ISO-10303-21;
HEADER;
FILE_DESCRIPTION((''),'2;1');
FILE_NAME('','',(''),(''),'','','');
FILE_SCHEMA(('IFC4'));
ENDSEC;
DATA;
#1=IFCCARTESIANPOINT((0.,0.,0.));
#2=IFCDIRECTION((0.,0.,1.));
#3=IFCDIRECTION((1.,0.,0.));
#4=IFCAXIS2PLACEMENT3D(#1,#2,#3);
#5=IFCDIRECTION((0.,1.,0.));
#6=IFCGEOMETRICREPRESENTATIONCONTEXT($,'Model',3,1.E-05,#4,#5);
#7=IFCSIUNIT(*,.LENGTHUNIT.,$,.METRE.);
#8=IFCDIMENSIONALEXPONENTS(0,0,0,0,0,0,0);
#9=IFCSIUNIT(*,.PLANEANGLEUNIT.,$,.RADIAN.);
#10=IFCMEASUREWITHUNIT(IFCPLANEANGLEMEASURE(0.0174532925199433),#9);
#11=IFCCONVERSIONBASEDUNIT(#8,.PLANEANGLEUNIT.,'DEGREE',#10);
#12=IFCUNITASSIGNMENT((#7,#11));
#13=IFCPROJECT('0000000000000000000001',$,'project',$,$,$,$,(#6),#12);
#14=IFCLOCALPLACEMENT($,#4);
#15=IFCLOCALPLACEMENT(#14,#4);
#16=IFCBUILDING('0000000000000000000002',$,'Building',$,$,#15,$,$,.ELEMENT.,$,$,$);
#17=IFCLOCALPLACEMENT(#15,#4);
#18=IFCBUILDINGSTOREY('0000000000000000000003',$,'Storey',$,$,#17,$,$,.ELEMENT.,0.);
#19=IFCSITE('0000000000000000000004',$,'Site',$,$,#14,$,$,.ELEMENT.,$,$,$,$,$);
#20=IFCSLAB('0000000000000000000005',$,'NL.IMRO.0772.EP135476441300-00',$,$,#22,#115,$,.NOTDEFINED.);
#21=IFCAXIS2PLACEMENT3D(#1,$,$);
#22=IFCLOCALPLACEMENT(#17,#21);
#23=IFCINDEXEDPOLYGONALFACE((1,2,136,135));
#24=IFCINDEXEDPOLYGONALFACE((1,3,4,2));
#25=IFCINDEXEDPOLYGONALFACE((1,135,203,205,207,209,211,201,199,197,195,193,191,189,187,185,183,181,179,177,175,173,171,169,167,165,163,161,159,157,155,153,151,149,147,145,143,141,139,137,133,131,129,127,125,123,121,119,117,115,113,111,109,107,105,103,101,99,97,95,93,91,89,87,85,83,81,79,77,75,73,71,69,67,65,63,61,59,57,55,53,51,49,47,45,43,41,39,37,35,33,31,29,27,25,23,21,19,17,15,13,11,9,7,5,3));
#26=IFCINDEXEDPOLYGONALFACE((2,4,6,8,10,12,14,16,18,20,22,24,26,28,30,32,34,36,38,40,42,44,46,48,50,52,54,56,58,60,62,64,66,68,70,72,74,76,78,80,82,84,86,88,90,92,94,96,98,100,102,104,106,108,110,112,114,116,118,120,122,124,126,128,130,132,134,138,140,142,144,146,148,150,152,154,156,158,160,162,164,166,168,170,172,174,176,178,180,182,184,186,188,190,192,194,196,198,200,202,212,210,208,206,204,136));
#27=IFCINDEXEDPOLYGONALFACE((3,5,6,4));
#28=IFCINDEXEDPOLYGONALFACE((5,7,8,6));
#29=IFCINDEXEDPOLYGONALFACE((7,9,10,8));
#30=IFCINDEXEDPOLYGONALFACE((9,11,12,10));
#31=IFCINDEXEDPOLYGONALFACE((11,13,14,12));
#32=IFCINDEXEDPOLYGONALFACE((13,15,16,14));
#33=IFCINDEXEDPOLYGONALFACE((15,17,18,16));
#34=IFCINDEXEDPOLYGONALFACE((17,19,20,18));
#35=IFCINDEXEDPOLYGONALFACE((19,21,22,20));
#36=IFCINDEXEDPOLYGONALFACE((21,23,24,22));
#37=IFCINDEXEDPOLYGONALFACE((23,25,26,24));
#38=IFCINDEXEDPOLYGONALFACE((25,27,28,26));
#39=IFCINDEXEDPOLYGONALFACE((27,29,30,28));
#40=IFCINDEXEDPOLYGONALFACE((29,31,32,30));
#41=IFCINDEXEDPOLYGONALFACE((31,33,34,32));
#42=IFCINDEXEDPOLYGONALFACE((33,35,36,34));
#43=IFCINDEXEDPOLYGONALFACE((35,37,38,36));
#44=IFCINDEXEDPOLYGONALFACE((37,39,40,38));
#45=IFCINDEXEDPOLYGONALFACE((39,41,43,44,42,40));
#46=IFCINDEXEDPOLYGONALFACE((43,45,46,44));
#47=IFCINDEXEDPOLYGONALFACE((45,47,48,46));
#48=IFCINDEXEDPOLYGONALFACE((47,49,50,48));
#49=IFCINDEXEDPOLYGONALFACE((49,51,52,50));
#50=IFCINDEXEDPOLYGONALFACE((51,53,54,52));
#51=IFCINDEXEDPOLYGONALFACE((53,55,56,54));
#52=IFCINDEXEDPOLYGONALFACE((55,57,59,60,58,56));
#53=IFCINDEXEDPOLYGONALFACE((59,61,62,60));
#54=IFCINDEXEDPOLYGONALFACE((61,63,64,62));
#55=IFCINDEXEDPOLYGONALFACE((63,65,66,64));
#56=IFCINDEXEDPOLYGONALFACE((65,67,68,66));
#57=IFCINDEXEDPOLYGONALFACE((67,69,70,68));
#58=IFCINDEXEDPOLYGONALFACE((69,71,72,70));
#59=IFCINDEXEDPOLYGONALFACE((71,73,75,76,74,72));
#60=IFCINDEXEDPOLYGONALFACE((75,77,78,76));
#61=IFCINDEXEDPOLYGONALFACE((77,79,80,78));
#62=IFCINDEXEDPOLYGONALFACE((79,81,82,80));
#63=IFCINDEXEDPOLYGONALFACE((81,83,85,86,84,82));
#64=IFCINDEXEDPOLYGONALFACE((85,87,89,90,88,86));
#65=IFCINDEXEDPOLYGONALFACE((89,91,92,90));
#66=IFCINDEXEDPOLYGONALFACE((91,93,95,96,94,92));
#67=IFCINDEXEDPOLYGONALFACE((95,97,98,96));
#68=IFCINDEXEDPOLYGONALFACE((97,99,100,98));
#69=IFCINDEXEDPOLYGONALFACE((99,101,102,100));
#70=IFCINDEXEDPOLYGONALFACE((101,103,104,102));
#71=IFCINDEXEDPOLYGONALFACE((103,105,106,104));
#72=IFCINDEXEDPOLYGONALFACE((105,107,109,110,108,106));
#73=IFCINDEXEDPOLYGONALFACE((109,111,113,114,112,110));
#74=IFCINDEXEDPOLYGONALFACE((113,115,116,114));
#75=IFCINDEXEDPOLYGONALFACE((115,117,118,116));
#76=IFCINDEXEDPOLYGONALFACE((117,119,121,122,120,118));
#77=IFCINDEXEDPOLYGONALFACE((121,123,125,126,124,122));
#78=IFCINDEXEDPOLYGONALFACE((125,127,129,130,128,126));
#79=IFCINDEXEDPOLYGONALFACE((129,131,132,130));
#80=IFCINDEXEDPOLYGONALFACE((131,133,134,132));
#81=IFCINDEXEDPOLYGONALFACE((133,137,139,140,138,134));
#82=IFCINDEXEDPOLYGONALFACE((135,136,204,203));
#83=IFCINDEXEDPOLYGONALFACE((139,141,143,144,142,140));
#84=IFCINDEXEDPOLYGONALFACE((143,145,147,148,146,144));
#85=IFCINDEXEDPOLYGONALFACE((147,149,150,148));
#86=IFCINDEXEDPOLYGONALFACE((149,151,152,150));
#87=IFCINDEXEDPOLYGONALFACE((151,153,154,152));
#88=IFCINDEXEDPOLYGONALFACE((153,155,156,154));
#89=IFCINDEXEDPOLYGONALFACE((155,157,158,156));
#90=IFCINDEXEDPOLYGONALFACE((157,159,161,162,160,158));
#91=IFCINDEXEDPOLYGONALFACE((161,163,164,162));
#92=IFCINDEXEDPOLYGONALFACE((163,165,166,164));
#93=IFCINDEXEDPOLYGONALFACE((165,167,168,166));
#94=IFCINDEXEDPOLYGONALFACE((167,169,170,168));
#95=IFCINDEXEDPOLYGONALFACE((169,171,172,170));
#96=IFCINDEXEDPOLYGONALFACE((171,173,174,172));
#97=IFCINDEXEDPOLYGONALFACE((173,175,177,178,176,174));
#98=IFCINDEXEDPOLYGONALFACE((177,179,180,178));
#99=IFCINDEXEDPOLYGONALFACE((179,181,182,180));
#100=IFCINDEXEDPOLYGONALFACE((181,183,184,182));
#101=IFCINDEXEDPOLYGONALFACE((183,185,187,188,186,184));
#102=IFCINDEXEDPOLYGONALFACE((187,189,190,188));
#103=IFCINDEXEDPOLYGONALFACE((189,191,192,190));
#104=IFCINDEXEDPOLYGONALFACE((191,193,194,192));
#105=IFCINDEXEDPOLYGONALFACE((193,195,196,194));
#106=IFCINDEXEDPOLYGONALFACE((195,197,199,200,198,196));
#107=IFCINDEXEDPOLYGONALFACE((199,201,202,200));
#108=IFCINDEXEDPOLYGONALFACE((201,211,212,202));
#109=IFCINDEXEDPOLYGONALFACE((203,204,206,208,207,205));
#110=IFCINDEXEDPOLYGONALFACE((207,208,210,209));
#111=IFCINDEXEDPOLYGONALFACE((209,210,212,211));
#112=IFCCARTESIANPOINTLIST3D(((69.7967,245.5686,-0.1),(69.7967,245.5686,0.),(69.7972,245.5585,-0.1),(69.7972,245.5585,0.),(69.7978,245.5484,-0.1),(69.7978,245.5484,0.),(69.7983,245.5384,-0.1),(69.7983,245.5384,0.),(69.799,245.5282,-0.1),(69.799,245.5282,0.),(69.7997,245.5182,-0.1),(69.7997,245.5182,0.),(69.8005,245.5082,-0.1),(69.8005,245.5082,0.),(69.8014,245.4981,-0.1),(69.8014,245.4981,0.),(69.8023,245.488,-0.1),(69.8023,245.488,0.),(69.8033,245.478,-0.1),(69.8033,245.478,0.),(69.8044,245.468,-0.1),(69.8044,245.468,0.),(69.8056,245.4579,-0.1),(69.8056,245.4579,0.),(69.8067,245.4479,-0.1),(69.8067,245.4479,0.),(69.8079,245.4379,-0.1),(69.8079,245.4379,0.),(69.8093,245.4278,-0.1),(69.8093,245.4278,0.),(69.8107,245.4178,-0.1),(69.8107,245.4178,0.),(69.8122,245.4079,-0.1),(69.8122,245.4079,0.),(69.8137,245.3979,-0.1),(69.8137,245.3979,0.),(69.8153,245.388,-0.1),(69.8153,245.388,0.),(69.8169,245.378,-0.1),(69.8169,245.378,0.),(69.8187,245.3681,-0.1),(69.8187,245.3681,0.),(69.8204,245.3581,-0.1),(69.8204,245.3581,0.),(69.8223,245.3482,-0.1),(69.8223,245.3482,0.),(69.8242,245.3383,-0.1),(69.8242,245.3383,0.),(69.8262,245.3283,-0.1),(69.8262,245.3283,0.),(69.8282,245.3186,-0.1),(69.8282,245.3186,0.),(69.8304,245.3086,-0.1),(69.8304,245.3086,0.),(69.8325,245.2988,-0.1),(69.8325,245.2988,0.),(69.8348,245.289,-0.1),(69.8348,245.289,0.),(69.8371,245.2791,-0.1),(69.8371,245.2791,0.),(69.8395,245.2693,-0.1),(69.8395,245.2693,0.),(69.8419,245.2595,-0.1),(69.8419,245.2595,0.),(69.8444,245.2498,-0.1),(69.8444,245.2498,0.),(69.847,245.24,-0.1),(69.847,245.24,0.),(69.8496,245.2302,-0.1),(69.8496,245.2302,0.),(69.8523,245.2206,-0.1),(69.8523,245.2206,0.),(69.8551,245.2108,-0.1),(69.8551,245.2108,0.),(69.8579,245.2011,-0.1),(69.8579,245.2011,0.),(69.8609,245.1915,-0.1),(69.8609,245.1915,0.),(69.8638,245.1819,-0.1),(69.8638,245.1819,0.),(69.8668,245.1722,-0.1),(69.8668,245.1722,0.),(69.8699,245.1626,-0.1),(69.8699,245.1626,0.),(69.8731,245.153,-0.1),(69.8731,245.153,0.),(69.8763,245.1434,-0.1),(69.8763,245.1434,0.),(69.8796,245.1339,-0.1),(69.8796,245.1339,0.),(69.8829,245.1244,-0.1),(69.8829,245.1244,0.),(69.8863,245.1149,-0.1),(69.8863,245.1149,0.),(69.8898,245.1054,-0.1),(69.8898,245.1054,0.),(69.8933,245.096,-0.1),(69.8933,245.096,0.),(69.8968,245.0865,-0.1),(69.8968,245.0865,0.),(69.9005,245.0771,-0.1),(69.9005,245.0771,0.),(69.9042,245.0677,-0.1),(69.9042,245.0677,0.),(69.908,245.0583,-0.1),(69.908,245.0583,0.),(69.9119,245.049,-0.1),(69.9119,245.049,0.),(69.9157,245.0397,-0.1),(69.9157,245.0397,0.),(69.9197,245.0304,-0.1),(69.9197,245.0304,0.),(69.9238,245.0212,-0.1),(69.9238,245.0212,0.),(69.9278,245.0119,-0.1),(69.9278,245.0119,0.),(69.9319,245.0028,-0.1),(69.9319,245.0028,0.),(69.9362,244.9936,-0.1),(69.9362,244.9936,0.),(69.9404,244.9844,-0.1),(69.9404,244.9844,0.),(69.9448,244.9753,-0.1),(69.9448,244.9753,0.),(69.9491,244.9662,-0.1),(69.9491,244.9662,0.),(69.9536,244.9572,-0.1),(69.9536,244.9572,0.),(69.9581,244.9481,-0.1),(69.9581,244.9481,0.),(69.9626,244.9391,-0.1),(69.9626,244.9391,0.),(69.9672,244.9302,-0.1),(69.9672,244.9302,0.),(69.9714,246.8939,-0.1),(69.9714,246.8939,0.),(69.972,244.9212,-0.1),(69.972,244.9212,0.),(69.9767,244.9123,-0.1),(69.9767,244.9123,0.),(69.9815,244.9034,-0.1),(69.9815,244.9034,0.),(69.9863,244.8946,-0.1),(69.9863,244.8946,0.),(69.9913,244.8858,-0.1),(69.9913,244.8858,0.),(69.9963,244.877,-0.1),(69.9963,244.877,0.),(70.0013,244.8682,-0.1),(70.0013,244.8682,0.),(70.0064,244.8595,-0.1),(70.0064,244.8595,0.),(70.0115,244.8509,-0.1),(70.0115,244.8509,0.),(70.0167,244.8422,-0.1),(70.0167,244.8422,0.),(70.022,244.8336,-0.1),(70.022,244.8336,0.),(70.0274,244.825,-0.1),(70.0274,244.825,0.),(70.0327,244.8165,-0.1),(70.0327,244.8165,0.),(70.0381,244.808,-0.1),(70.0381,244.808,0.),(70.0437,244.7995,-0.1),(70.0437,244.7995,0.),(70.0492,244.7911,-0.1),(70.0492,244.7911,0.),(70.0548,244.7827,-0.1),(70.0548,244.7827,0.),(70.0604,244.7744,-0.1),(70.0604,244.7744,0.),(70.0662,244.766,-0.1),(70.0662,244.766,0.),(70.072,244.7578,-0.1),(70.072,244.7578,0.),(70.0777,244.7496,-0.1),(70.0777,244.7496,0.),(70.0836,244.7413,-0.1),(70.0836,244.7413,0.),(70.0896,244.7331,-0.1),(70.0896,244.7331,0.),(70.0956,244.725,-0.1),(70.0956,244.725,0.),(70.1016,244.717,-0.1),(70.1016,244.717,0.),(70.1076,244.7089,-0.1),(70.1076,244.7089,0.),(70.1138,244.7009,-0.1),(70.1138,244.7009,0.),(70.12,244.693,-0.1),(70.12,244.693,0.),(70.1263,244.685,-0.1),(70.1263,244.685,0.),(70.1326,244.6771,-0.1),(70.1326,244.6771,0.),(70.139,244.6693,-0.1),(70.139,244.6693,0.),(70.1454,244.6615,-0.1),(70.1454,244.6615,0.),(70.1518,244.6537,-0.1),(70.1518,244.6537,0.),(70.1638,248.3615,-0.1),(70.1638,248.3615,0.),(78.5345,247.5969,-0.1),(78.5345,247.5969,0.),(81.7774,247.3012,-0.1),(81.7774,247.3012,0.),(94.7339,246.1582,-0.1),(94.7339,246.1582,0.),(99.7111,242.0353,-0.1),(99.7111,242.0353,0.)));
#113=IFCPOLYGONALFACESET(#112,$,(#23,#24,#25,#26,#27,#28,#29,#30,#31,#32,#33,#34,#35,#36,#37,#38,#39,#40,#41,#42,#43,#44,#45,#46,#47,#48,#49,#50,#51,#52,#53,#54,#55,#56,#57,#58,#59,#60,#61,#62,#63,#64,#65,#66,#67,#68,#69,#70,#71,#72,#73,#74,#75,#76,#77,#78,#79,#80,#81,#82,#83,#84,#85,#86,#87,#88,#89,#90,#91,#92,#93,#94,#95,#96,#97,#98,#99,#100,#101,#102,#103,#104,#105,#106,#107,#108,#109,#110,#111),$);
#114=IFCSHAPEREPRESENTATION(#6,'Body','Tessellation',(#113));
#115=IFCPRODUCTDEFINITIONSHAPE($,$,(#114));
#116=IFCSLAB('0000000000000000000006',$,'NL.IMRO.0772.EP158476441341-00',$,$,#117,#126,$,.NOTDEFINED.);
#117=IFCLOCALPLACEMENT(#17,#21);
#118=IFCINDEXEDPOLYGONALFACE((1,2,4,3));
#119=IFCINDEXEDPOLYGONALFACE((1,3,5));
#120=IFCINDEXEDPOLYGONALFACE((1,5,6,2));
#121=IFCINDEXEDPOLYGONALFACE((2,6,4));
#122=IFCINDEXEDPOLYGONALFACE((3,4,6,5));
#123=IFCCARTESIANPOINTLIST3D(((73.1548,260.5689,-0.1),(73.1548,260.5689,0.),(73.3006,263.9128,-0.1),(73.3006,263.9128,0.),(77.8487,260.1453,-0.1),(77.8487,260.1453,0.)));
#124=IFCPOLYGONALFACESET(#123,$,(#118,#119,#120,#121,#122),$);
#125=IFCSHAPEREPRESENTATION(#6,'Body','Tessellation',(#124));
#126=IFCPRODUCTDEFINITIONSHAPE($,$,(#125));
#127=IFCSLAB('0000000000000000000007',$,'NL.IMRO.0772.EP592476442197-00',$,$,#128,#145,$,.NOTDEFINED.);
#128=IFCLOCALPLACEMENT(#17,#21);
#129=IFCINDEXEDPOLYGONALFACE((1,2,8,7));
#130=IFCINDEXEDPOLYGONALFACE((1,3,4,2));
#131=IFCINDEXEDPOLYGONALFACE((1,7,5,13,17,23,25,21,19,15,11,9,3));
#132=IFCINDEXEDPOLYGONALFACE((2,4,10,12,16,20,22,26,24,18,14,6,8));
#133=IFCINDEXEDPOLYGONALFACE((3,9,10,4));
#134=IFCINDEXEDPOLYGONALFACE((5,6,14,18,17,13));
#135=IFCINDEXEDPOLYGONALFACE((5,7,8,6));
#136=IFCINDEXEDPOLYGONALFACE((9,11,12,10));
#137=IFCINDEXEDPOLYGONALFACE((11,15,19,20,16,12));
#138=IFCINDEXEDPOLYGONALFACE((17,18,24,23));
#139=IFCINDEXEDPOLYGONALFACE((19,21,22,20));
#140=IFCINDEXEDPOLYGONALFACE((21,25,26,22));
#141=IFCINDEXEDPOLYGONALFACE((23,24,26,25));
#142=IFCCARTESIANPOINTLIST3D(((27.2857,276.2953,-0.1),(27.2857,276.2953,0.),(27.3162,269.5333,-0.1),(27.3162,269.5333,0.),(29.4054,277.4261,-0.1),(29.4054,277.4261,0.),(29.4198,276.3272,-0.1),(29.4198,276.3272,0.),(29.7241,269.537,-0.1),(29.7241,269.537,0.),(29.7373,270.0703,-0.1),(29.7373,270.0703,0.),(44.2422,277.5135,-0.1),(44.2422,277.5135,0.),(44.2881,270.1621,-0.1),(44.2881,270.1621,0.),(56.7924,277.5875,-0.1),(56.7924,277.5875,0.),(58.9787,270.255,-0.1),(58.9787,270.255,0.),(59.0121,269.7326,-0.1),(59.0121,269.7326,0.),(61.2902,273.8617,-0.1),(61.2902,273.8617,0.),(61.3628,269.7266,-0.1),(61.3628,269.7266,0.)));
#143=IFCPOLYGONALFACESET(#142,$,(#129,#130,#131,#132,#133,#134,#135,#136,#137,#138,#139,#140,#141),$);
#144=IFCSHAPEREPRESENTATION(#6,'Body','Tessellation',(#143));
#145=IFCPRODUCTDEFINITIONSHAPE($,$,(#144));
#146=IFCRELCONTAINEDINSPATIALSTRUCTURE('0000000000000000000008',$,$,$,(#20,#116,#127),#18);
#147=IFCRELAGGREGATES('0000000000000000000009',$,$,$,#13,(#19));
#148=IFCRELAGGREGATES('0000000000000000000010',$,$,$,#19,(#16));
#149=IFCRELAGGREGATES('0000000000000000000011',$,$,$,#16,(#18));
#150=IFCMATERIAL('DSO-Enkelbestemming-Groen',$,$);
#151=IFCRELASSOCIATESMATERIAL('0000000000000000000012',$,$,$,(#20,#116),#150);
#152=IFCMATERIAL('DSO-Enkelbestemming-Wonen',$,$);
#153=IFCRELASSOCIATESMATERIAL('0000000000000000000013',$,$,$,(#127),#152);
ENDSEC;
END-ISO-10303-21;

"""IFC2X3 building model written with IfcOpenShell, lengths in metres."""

from ifc_helpers import new_model, entity, si_unit, converted_unit, direction, frame, origin_with_axes, place, context, project, spatial, polyline, outline, extrude, material, element, save


model = new_model("IFC2X3")

# Units and contexts
model_context = context("Model", 3, precision=1e-05, world=origin_with_axes(), true_north=direction((0.0, 1.0, 0.0)))
ifc_project = project(units=[si_unit("LENGTHUNIT", "METRE"), converted_unit("PLANEANGLEUNIT", "DEGREE", entity("IfcPlaneAngleMeasure", 0.0174532925199433), si_unit("PLANEANGLEUNIT", "RADIAN"), dimensions=[0, 0, 0, 0, 0, 0, 0])], contexts=[model_context])

# Site, building, storey
site_placement = place(None, origin_with_axes())
site = spatial("IfcSite", under=ifc_project, at=site_placement, Name="Site", CompositionType="ELEMENT")
building_placement = place(site_placement, origin_with_axes())
building = spatial("IfcBuilding", under=site, at=building_placement, Name="Building", CompositionType="ELEMENT")
storey_placement = place(building_placement, origin_with_axes())
storey = spatial("IfcBuildingStorey", under=building, at=storey_placement, Name="Storey", CompositionType="ELEMENT", Elevation=0.0)

# Slabs
ifc_material_1 = material(Name="DSO-Enkelbestemming-Wonen")
ifc_material_2 = material(Name="DSO-Enkelbestemming-Groen")
slab_1_placement = place(storey_placement, frame((0.0, 0.0, -0.1), z_axis=(0.0, 0.0, 1.0), x_axis=(1.0, 0.0, 0.0)))
element("IfcSlab", 1, at=slab_1_placement, inside=storey, material=ifc_material_2, Name="NL.IMRO.0772.EP135476441300-00", PredefinedType="NOTDEFINED", context=model_context, shape_type="SweptSolid", body=[
    extrude(outline(polyline([(70.1518, 244.6537), (70.1454, 244.6615), (70.139, 244.6693), (70.1326, 244.6771), (70.1263, 244.685), (70.12, 244.693), (70.1138, 244.7009), (70.1076, 244.7089), (70.1016, 244.717), (70.0956, 244.725), (70.0896, 244.7331), (70.0836, 244.7413), (70.0777, 244.7496), (70.072, 244.7578), (70.0662, 244.766), (70.0604, 244.7744), (70.0548, 244.7827), (70.0492, 244.7911), (70.0437, 244.7995), (70.0381, 244.808), (70.0327, 244.8165), (70.0274, 244.825), (70.022, 244.8336), (70.0167, 244.8422), (70.0115, 244.8509), (70.0064, 244.8595), (70.0013, 244.8682), (69.9963, 244.877), (69.9913, 244.8858), (69.9863, 244.8946), (69.9815, 244.9034), (69.9767, 244.9123), (69.972, 244.9212), (69.9672, 244.9302), (69.9626, 244.9391), (69.9581, 244.9481), (69.9536, 244.9572), (69.9491, 244.9662), (69.9448, 244.9753), (69.9404, 244.9844), (69.9362, 244.9936), (69.9319, 245.0028), (69.9278, 245.0119), (69.9238, 245.0212), (69.9197, 245.0304), (69.9157, 245.0397), (69.9119, 245.049), (69.908, 245.0583), (69.9042, 245.0677), (69.9005, 245.0771), (69.8968, 245.0865), (69.8933, 245.096), (69.8898, 245.1054), (69.8863, 245.1149), (69.8829, 245.1244), (69.8796, 245.1339), (69.8763, 245.1434), (69.8731, 245.153), (69.8699, 245.1626), (69.8668, 245.1722), (69.8638, 245.1819), (69.8609, 245.1915), (69.8579, 245.2011), (69.8551, 245.2108), (69.8523, 245.2206), (69.8496, 245.2302), (69.847, 245.24), (69.8444, 245.2498), (69.8419, 245.2595), (69.8395, 245.2693), (69.8371, 245.2791), (69.8348, 245.289), (69.8325, 245.2988), (69.8304, 245.3086), (69.8282, 245.3186), (69.8262, 245.3283), (69.8242, 245.3383), (69.8223, 245.3482), (69.8204, 245.3581), (69.8187, 245.3681), (69.8169, 245.378), (69.8153, 245.388), (69.8137, 245.3979), (69.8122, 245.4079), (69.8107, 245.4178), (69.8093, 245.4278), (69.8079, 245.4379), (69.8067, 245.4479), (69.8056, 245.4579), (69.8044, 245.468), (69.8033, 245.478), (69.8023, 245.488), (69.8014, 245.4981), (69.8005, 245.5082), (69.7997, 245.5182), (69.799, 245.5282), (69.7983, 245.5384), (69.7978, 245.5484), (69.7972, 245.5585), (69.7967, 245.5686), (69.9714, 246.8939), (70.1638, 248.3615), (78.5345, 247.5969), (81.7774, 247.3012), (94.7339, 246.1582), (99.7111, 242.0353), (70.1518, 244.6537)])), origin_with_axes(), (0.0, 0.0, 1.0), 0.1),
])
slab_2_placement = place(storey_placement, frame((0.0, 0.0, -0.1), z_axis=(0.0, 0.0, 1.0), x_axis=(1.0, 0.0, 0.0)))
element("IfcSlab", 2, at=slab_2_placement, inside=storey, material=ifc_material_2, Name="NL.IMRO.0772.EP158476441341-00", PredefinedType="NOTDEFINED", context=model_context, shape_type="SweptSolid", body=[
    extrude(outline(polyline([(73.1548, 260.5689), (73.3006, 263.9128), (77.8487, 260.1453), (73.1548, 260.5689)])), origin_with_axes(), (0.0, 0.0, 1.0), 0.1),
])
slab_3_placement = place(storey_placement, frame((0.0, 0.0, -0.1), z_axis=(0.0, 0.0, 1.0), x_axis=(1.0, 0.0, 0.0)))
element("IfcSlab", 3, at=slab_3_placement, inside=storey, material=ifc_material_1, Name="NL.IMRO.0772.EP592476442197-00", PredefinedType="NOTDEFINED", context=model_context, shape_type="SweptSolid", body=[
    extrude(outline(polyline([(61.3628, 269.7266), (59.0121, 269.7326), (58.9787, 270.255), (44.2881, 270.1621), (29.7373, 270.0703), (29.7241, 269.537), (27.3162, 269.5333), (27.2857, 276.2953), (29.4198, 276.3272), (29.4054, 277.4261), (44.2422, 277.5135), (56.7924, 277.5875), (61.2902, 273.8617), (61.3628, 269.7266)])), origin_with_axes(), (0.0, 0.0, 1.0), 0.1),
])

save(model, "model.ifc")
